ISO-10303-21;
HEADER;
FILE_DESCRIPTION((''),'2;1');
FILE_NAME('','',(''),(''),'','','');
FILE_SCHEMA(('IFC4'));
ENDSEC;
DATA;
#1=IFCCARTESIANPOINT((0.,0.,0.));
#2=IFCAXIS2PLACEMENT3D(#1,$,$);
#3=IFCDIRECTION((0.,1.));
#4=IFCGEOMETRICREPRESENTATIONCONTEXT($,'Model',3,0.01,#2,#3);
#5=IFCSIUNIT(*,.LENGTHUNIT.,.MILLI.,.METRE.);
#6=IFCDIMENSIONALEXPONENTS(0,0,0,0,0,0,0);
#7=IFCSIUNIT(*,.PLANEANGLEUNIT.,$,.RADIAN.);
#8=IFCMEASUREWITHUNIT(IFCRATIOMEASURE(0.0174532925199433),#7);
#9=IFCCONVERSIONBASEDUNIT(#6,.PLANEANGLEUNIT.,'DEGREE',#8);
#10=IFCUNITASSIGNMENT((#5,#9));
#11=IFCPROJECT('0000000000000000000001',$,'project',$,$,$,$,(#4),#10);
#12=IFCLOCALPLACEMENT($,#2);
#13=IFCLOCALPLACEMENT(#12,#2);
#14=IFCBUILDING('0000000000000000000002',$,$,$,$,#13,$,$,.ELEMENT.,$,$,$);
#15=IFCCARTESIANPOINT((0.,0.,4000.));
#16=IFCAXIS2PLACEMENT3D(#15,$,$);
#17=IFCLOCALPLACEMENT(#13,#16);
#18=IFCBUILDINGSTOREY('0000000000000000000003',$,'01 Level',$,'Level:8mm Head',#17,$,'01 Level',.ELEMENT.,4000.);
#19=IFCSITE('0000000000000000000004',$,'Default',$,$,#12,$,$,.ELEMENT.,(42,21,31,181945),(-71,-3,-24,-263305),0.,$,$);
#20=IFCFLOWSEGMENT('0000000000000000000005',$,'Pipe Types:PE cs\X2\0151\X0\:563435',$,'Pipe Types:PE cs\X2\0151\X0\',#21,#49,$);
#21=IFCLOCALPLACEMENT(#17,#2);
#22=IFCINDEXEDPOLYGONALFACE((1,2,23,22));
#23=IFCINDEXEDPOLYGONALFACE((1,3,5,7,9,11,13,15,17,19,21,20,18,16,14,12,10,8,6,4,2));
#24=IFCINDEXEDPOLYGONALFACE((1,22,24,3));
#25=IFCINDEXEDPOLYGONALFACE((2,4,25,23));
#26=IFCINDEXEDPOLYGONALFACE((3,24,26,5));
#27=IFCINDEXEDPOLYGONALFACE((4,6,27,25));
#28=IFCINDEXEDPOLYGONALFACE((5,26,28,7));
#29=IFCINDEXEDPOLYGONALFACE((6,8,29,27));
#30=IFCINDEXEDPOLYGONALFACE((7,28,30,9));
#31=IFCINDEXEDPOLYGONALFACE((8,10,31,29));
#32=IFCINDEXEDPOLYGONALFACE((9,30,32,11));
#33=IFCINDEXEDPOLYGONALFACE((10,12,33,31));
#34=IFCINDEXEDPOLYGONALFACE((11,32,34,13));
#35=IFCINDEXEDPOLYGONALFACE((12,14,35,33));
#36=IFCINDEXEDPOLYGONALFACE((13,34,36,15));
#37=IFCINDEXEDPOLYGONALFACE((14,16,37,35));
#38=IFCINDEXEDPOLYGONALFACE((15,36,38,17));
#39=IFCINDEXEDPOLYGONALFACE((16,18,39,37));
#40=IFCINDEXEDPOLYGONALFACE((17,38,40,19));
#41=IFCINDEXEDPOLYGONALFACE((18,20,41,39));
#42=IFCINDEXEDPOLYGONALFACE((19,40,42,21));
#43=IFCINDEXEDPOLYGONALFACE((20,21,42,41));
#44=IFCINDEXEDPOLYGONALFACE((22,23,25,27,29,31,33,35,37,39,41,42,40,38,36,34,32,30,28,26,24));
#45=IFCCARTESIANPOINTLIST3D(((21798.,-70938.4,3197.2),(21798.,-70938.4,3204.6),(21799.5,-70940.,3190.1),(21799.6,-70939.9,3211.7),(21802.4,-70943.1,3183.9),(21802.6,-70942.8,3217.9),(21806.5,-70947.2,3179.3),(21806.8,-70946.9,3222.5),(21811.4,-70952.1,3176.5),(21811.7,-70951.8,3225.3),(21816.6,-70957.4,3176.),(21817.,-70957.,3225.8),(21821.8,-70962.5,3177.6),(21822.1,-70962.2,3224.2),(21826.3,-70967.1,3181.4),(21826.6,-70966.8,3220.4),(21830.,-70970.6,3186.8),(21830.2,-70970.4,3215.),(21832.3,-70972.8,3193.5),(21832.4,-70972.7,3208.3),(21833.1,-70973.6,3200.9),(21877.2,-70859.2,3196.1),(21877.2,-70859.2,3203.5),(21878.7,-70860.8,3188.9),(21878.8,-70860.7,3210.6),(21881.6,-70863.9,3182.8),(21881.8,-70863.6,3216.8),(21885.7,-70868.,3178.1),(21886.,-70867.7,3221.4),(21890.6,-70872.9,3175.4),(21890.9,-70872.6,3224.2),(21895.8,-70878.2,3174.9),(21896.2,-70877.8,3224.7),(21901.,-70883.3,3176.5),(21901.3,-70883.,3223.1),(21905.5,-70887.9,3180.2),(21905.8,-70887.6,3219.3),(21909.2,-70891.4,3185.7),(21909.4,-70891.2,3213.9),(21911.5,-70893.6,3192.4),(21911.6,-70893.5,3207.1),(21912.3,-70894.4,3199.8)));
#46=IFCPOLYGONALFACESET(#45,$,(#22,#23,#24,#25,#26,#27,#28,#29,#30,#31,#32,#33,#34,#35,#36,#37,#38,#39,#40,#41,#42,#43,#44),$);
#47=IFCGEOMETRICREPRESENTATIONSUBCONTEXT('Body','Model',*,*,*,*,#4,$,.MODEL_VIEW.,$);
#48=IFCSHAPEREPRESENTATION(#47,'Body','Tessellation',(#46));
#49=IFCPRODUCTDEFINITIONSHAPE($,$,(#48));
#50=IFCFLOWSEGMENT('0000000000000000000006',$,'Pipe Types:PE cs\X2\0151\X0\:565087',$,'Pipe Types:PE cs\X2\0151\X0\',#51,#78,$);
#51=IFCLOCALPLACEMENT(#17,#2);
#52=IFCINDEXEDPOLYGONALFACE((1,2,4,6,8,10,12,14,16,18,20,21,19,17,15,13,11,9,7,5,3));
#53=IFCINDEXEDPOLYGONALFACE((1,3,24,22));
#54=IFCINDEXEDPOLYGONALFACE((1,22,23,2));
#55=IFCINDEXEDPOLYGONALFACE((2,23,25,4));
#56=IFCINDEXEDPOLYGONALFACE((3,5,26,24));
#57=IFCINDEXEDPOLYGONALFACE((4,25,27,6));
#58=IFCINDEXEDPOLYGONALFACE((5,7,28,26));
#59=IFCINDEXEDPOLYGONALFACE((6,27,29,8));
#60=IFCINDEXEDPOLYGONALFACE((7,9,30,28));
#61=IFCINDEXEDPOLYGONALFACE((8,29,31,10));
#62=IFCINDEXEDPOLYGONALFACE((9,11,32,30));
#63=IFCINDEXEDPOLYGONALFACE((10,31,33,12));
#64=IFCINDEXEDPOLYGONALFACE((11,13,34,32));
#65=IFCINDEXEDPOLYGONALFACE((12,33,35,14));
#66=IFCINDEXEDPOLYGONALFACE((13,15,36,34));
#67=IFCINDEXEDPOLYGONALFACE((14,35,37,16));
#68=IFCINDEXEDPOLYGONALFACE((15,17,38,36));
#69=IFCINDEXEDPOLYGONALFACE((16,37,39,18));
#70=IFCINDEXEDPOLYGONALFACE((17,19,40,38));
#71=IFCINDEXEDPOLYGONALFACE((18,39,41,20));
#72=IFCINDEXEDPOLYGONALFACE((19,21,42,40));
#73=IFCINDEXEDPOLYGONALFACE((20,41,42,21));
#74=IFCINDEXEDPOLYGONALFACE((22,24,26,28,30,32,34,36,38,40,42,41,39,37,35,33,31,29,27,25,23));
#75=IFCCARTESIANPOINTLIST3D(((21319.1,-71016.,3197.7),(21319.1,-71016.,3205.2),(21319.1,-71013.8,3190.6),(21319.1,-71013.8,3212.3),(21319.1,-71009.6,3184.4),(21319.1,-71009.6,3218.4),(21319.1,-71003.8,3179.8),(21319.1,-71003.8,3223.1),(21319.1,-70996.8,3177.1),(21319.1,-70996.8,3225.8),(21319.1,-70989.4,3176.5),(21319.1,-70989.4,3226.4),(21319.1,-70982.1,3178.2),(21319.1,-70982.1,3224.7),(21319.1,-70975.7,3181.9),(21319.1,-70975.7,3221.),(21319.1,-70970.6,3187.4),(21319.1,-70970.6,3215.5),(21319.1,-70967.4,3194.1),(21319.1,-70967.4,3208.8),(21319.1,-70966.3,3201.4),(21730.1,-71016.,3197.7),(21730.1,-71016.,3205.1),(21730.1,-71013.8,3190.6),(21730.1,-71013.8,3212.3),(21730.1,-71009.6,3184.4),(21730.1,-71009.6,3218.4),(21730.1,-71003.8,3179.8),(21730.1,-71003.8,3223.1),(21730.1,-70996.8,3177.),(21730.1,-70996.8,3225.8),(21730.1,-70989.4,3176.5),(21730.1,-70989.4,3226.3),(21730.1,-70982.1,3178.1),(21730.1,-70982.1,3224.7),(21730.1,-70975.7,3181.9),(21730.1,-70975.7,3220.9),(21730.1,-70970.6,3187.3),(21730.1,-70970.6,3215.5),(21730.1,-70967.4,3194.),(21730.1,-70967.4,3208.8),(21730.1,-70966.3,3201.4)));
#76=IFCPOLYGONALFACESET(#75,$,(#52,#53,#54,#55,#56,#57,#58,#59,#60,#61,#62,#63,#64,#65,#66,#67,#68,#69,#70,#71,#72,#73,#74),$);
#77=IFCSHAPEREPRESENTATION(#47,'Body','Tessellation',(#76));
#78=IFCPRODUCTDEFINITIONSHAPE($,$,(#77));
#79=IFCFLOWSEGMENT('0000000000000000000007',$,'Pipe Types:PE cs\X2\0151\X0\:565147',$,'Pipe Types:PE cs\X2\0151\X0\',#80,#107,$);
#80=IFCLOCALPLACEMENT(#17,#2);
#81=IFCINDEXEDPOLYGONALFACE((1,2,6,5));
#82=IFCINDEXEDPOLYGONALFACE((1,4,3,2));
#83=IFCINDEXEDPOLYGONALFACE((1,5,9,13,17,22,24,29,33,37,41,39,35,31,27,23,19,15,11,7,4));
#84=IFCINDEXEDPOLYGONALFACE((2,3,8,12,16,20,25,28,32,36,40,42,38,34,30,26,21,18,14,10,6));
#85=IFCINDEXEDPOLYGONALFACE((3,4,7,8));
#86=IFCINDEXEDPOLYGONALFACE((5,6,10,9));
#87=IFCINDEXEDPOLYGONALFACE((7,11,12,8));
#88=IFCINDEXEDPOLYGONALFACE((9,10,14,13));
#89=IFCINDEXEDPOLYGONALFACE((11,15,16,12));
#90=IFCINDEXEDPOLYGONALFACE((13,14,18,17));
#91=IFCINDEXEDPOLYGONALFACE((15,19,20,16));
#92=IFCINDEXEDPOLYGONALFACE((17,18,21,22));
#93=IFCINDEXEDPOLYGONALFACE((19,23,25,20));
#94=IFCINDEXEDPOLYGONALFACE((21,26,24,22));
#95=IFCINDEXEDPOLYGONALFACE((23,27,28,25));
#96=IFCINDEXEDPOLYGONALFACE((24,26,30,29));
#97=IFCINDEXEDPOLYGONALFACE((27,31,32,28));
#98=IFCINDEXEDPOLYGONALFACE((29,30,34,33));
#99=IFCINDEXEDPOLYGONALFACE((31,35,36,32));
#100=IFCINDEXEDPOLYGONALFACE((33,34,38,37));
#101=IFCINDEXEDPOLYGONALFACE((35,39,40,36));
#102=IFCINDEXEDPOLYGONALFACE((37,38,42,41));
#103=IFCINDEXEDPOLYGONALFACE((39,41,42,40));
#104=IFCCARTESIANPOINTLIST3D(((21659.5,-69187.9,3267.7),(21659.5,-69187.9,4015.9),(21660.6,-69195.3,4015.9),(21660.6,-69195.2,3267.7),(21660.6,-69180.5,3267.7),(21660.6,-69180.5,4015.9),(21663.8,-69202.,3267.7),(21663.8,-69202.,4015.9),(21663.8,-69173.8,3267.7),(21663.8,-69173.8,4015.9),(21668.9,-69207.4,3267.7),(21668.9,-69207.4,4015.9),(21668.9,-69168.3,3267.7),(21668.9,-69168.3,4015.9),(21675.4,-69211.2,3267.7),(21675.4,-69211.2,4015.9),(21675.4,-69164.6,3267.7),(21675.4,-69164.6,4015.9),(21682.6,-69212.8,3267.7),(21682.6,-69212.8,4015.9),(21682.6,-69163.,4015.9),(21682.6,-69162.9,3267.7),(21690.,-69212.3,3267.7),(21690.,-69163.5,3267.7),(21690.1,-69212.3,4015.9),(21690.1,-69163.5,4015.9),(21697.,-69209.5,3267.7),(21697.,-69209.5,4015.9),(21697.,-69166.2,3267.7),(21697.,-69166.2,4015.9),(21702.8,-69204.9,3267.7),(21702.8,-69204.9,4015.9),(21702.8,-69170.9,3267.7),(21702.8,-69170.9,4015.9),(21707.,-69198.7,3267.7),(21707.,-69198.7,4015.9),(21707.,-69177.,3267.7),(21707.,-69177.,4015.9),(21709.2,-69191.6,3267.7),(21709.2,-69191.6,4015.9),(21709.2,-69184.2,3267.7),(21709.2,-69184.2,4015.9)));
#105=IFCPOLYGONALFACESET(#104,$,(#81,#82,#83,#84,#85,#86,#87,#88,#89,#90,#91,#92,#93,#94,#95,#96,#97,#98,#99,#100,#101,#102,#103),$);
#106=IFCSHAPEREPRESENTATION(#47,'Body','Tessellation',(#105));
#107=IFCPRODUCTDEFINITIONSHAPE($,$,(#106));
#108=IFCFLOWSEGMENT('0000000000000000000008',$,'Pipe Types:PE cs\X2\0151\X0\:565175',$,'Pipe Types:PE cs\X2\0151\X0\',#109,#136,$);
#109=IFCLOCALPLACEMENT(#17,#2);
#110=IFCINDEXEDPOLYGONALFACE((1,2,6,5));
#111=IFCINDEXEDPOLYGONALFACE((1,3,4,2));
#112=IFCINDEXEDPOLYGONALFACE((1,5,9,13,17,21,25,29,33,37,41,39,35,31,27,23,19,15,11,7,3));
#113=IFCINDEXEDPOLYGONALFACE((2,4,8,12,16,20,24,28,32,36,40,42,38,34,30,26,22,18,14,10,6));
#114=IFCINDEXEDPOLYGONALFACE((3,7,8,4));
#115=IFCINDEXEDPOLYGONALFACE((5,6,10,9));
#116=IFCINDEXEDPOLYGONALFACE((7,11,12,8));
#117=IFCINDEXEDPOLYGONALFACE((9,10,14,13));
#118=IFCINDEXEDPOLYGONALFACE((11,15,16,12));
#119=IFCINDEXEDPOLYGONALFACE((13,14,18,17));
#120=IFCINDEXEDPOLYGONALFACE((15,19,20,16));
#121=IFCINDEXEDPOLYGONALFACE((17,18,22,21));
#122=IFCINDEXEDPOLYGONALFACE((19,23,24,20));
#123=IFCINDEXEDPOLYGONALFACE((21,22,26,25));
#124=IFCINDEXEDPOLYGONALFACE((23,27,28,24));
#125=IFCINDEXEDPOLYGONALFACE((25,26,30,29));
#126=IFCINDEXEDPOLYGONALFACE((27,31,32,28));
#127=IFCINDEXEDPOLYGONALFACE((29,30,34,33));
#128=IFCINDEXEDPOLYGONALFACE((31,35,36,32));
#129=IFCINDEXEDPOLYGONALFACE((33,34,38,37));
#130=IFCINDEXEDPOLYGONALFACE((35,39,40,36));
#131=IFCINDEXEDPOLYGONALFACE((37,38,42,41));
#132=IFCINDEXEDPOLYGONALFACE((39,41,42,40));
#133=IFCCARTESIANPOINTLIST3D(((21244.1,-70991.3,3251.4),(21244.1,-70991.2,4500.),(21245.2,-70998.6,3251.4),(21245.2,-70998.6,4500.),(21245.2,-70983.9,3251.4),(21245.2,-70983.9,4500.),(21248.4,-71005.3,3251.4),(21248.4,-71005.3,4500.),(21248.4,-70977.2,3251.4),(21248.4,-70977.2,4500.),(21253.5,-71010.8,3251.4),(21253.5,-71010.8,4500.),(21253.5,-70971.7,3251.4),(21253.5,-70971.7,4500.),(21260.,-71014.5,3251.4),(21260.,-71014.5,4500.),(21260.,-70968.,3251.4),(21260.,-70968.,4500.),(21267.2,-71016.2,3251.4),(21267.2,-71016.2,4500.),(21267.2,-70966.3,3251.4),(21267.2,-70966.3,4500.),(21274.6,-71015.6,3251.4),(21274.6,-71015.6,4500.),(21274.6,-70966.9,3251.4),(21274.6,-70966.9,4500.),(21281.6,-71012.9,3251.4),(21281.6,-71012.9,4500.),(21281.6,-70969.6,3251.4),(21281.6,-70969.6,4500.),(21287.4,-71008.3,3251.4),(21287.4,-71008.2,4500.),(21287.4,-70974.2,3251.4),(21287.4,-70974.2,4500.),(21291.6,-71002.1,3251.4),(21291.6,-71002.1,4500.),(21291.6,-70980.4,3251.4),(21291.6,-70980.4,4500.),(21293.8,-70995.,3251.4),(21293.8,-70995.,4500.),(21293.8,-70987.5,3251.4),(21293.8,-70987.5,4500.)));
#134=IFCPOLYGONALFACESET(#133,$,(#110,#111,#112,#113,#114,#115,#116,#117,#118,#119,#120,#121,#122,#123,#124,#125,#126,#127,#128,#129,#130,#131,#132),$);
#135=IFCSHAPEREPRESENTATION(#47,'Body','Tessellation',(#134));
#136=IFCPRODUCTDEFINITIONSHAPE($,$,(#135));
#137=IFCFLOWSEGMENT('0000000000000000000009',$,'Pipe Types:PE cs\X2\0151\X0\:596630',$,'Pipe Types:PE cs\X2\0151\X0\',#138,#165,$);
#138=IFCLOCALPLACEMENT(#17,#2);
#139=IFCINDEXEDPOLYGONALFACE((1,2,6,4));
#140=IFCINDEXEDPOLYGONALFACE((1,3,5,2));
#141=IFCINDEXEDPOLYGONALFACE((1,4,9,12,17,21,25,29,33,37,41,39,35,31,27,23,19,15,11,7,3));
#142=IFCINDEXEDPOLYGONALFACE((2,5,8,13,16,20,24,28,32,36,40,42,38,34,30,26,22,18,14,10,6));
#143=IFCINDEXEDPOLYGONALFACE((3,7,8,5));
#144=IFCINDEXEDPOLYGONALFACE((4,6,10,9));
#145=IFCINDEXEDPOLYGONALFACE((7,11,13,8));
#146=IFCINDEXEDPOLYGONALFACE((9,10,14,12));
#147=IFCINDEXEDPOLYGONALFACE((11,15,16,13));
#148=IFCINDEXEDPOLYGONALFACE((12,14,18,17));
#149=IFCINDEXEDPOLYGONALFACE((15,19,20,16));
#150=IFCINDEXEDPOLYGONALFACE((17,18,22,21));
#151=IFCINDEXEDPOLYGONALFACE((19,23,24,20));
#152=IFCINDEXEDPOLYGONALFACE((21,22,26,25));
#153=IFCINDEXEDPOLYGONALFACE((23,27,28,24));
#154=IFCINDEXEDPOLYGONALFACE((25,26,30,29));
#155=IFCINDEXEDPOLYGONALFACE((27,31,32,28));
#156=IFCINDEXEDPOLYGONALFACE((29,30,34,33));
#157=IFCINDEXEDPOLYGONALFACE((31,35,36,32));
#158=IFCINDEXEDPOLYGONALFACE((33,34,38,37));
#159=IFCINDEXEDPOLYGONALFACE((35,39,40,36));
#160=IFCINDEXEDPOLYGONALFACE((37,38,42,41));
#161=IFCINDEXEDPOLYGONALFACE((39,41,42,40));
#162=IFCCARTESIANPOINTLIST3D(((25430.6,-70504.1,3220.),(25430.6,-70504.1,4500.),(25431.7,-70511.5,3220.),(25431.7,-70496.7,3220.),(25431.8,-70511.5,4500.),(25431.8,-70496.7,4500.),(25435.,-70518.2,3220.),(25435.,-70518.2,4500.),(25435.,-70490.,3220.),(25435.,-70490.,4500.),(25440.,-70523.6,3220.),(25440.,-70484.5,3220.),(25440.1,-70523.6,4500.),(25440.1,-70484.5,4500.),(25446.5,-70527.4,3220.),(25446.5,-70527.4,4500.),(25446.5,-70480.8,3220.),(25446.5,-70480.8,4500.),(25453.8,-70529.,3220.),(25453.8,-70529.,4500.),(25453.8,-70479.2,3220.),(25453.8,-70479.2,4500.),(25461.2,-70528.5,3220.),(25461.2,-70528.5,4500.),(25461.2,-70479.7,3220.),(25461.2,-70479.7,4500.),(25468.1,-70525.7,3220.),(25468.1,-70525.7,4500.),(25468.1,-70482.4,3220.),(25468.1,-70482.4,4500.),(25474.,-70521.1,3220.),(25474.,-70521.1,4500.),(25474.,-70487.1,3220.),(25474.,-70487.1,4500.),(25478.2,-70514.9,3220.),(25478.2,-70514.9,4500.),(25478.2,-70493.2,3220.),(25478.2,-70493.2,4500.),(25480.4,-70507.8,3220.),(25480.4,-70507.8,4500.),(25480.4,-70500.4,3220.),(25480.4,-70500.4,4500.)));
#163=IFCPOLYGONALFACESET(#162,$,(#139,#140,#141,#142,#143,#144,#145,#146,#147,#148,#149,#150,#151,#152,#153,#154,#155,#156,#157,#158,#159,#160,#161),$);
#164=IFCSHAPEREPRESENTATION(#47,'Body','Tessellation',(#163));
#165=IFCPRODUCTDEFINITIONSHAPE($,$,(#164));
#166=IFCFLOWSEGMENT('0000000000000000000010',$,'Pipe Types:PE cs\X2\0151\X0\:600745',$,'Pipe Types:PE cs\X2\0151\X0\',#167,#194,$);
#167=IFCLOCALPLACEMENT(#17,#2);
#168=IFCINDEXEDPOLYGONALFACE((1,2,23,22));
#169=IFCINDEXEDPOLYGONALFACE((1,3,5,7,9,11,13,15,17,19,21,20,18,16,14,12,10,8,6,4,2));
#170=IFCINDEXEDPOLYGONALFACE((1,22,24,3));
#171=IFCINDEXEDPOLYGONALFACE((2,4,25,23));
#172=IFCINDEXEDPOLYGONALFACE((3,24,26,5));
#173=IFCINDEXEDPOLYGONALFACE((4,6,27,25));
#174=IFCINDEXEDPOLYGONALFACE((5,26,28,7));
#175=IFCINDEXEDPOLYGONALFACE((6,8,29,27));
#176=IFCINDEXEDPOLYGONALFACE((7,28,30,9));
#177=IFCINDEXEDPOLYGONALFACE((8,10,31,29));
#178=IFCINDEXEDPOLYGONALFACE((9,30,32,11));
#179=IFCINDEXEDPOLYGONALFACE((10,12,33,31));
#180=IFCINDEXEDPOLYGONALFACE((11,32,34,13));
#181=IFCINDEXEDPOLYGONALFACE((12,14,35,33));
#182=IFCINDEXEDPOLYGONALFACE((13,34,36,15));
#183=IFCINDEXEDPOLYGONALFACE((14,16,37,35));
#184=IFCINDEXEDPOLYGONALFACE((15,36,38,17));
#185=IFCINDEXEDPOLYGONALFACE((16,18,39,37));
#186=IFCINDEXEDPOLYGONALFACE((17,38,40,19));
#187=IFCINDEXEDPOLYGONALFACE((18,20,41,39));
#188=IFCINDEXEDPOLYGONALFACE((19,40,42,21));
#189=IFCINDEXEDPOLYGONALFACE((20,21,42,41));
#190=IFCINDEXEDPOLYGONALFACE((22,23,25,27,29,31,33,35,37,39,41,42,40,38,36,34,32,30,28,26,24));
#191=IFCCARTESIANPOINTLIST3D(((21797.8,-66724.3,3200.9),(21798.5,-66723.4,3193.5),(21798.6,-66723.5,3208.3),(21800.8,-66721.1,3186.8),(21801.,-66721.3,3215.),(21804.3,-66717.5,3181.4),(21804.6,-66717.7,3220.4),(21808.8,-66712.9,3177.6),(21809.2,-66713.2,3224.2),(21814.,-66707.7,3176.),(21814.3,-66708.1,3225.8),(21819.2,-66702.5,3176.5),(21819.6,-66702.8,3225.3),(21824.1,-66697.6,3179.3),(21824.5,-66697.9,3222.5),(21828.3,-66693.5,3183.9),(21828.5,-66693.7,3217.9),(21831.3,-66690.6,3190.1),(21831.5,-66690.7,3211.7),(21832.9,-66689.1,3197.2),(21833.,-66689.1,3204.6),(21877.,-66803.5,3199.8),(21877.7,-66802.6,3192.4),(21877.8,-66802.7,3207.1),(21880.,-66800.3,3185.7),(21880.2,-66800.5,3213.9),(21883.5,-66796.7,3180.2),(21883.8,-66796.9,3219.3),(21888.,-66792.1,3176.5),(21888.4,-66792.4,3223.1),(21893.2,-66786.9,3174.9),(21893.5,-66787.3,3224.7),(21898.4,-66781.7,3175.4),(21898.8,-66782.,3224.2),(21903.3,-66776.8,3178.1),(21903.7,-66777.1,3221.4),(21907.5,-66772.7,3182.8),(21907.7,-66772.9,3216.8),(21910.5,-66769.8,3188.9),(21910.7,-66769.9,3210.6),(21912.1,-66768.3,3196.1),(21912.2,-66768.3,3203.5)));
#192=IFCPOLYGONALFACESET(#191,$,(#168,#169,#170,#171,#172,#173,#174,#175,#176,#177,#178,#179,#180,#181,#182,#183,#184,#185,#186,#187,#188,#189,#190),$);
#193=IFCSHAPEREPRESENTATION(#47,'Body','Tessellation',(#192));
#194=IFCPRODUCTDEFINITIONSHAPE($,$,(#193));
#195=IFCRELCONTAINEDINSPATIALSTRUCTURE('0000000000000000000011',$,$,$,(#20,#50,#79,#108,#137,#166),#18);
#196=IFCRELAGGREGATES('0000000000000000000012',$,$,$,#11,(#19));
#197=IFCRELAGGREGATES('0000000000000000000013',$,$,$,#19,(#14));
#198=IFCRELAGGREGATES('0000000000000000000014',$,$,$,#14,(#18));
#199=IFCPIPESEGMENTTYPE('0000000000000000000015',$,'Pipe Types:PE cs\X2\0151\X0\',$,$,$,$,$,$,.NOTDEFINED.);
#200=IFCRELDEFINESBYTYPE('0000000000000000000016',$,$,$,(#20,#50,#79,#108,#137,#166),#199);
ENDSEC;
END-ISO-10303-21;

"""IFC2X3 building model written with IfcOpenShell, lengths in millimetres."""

from ifc_helpers import new_model, entity, si_unit, converted_unit, direction, frame, frame_2d, origin, origin_2d_with_axis, place, context, subcontext, project, spatial, circle, extrude, type_object, element, save


model = new_model("IFC2X3")

# Units and contexts
model_context = context("Model", 3, precision=0.01, world=origin(), true_north=direction((0.0, 1.0)))
body_context = subcontext(model_context, "Body", "Model", "MODEL_VIEW")
ifc_project = project(units=[si_unit("LENGTHUNIT", "METRE", prefix="MILLI"), converted_unit("PLANEANGLEUNIT", "DEGREE", entity("IfcRatioMeasure", 0.0174532925199433), si_unit("PLANEANGLEUNIT", "RADIAN"), dimensions=[0, 0, 0, 0, 0, 0, 0])], contexts=[model_context])

# Site, building, storey
site_placement = place(None, origin())
site = spatial("IfcSite", under=ifc_project, at=site_placement, Name="Default", CompositionType="ELEMENT", RefLatitude=(42, 21, 31, 181945), RefLongitude=(-71, -3, -24, -263305), RefElevation=0.0)
building_placement = place(site_placement, origin())
building = spatial("IfcBuilding", under=site, at=building_placement, CompositionType="ELEMENT")
storey_placement = place(building_placement, frame((0.0, 0.0, 4000.0)))
storey = spatial("IfcBuildingStorey", under=building, at=storey_placement, Name="01 Level", ObjectType="Level:8mm Head", LongName="01 Level", CompositionType="ELEMENT", Elevation=4000.0)

# Flow segments
pipe_segment_type = type_object("IfcPipeSegmentType", Name="Pipe Types:PE cső", PredefinedType="NOTDEFINED")
flow_segment_1_placement = place(storey_placement, frame((21796.2, -70975.2, 3173.2)))
element("IfcFlowSegment", 1, at=flow_segment_1_placement, inside=storey, type_object=pipe_segment_type, Name="Pipe Types:PE cső:563435", ObjectType="Pipe Types:PE cső", context=body_context, shape_type="SweptSolid", body=[
    extrude(circle(Radius=25.0, at=frame_2d((0.0, 0.0), x_axis=(1.0, 0.0))), frame((19.3, 19.3, 27.7), z_axis=(0.707071, 0.707071, -0.01), x_axis=(0.707107, -0.707107, 0.0)), (0.0, 0.0, 1.0), 112.0),
])
flow_segment_2_placement = place(storey_placement, frame((21319.1, -71017.8, 3174.8)))
element("IfcFlowSegment", 2, at=flow_segment_2_placement, inside=storey, type_object=pipe_segment_type, Name="Pipe Types:PE cső:565087", ObjectType="Pipe Types:PE cső", context=body_context, shape_type="SweptSolid", body=[
    extrude(circle(Radius=25.0, at=frame_2d((0.0, 0.0), x_axis=(1.0, 0.0))), frame((0.0, 26.6, 26.6), z_axis=(1.0, 0.0, -0.000085), x_axis=(0.0, 1.0, 0.0)), (0.0, 0.0, 1.0), 411.0),
])
flow_segment_3_placement = place(storey_placement, frame((21657.9, -69214.5, 3267.7)))
element("IfcFlowSegment", 3, at=flow_segment_3_placement, inside=storey, type_object=pipe_segment_type, Name="Pipe Types:PE cső:565147", ObjectType="Pipe Types:PE cső", context=body_context, shape_type="SweptSolid", body=[
    extrude(circle(Radius=25.0, at=frame_2d((0.0, 0.0), x_axis=(1.0, 0.0))), frame((26.6, 26.6, 0.0), z_axis=(0.000019, -0.000019, 1.0), x_axis=(-1.0, 0.0, 0.000019)), (0.0, 0.0, 1.0), 748.2),
])
flow_segment_4_placement = place(storey_placement, frame((21242.5, -71017.8, 3251.4)))
element("IfcFlowSegment", 4, at=flow_segment_4_placement, inside=storey, type_object=pipe_segment_type, Name="Pipe Types:PE cső:565175", ObjectType="Pipe Types:PE cső", context=body_context, shape_type="SweptSolid", body=[
    extrude(circle(Radius=25.0, at=frame_2d((0.0, 0.0), x_axis=(1.0, 0.0))), frame((26.6, 26.6, 0.0), z_axis=(0.0, 0.000009, 1.0), x_axis=(-1.0, 0.0, 0.0)), (0.0, 0.0, 1.0), 1248.6),
])
flow_segment_5_placement = place(storey_placement, frame((25429.0, -70530.7, 3220.0)))
element("IfcFlowSegment", 5, at=flow_segment_5_placement, inside=storey, type_object=pipe_segment_type, Name="Pipe Types:PE cső:596630", ObjectType="Pipe Types:PE cső", context=body_context, shape_type="SweptSolid", body=[
    extrude(circle(Radius=25.0, at=origin_2d_with_axis()), frame((26.6, 26.6, 0.0), z_axis=(0.000007, -0.000001, 1.0), x_axis=(-1.0, 0.0, 0.000007)), (0.0, 0.0, 1.0), 1280.0),
])
flow_segment_6_placement = place(storey_placement, frame((21796.2, -66805.1, 3173.2)))
element("IfcFlowSegment", 6, at=flow_segment_6_placement, inside=storey, type_object=pipe_segment_type, Name="Pipe Types:PE cső:600745", ObjectType="Pipe Types:PE cső", context=body_context, shape_type="SweptSolid", body=[
    extrude(circle(Radius=25.0, at=frame_2d((0.0, 0.0), x_axis=(1.0, 0.0))), frame((98.5, 19.3, 26.6), z_axis=(-0.707071, 0.707071, 0.01), x_axis=(-0.707107, -0.707107, 0.0)), (0.0, 0.0, 1.0), 112.0),
])

save(model, "model.ifc")
